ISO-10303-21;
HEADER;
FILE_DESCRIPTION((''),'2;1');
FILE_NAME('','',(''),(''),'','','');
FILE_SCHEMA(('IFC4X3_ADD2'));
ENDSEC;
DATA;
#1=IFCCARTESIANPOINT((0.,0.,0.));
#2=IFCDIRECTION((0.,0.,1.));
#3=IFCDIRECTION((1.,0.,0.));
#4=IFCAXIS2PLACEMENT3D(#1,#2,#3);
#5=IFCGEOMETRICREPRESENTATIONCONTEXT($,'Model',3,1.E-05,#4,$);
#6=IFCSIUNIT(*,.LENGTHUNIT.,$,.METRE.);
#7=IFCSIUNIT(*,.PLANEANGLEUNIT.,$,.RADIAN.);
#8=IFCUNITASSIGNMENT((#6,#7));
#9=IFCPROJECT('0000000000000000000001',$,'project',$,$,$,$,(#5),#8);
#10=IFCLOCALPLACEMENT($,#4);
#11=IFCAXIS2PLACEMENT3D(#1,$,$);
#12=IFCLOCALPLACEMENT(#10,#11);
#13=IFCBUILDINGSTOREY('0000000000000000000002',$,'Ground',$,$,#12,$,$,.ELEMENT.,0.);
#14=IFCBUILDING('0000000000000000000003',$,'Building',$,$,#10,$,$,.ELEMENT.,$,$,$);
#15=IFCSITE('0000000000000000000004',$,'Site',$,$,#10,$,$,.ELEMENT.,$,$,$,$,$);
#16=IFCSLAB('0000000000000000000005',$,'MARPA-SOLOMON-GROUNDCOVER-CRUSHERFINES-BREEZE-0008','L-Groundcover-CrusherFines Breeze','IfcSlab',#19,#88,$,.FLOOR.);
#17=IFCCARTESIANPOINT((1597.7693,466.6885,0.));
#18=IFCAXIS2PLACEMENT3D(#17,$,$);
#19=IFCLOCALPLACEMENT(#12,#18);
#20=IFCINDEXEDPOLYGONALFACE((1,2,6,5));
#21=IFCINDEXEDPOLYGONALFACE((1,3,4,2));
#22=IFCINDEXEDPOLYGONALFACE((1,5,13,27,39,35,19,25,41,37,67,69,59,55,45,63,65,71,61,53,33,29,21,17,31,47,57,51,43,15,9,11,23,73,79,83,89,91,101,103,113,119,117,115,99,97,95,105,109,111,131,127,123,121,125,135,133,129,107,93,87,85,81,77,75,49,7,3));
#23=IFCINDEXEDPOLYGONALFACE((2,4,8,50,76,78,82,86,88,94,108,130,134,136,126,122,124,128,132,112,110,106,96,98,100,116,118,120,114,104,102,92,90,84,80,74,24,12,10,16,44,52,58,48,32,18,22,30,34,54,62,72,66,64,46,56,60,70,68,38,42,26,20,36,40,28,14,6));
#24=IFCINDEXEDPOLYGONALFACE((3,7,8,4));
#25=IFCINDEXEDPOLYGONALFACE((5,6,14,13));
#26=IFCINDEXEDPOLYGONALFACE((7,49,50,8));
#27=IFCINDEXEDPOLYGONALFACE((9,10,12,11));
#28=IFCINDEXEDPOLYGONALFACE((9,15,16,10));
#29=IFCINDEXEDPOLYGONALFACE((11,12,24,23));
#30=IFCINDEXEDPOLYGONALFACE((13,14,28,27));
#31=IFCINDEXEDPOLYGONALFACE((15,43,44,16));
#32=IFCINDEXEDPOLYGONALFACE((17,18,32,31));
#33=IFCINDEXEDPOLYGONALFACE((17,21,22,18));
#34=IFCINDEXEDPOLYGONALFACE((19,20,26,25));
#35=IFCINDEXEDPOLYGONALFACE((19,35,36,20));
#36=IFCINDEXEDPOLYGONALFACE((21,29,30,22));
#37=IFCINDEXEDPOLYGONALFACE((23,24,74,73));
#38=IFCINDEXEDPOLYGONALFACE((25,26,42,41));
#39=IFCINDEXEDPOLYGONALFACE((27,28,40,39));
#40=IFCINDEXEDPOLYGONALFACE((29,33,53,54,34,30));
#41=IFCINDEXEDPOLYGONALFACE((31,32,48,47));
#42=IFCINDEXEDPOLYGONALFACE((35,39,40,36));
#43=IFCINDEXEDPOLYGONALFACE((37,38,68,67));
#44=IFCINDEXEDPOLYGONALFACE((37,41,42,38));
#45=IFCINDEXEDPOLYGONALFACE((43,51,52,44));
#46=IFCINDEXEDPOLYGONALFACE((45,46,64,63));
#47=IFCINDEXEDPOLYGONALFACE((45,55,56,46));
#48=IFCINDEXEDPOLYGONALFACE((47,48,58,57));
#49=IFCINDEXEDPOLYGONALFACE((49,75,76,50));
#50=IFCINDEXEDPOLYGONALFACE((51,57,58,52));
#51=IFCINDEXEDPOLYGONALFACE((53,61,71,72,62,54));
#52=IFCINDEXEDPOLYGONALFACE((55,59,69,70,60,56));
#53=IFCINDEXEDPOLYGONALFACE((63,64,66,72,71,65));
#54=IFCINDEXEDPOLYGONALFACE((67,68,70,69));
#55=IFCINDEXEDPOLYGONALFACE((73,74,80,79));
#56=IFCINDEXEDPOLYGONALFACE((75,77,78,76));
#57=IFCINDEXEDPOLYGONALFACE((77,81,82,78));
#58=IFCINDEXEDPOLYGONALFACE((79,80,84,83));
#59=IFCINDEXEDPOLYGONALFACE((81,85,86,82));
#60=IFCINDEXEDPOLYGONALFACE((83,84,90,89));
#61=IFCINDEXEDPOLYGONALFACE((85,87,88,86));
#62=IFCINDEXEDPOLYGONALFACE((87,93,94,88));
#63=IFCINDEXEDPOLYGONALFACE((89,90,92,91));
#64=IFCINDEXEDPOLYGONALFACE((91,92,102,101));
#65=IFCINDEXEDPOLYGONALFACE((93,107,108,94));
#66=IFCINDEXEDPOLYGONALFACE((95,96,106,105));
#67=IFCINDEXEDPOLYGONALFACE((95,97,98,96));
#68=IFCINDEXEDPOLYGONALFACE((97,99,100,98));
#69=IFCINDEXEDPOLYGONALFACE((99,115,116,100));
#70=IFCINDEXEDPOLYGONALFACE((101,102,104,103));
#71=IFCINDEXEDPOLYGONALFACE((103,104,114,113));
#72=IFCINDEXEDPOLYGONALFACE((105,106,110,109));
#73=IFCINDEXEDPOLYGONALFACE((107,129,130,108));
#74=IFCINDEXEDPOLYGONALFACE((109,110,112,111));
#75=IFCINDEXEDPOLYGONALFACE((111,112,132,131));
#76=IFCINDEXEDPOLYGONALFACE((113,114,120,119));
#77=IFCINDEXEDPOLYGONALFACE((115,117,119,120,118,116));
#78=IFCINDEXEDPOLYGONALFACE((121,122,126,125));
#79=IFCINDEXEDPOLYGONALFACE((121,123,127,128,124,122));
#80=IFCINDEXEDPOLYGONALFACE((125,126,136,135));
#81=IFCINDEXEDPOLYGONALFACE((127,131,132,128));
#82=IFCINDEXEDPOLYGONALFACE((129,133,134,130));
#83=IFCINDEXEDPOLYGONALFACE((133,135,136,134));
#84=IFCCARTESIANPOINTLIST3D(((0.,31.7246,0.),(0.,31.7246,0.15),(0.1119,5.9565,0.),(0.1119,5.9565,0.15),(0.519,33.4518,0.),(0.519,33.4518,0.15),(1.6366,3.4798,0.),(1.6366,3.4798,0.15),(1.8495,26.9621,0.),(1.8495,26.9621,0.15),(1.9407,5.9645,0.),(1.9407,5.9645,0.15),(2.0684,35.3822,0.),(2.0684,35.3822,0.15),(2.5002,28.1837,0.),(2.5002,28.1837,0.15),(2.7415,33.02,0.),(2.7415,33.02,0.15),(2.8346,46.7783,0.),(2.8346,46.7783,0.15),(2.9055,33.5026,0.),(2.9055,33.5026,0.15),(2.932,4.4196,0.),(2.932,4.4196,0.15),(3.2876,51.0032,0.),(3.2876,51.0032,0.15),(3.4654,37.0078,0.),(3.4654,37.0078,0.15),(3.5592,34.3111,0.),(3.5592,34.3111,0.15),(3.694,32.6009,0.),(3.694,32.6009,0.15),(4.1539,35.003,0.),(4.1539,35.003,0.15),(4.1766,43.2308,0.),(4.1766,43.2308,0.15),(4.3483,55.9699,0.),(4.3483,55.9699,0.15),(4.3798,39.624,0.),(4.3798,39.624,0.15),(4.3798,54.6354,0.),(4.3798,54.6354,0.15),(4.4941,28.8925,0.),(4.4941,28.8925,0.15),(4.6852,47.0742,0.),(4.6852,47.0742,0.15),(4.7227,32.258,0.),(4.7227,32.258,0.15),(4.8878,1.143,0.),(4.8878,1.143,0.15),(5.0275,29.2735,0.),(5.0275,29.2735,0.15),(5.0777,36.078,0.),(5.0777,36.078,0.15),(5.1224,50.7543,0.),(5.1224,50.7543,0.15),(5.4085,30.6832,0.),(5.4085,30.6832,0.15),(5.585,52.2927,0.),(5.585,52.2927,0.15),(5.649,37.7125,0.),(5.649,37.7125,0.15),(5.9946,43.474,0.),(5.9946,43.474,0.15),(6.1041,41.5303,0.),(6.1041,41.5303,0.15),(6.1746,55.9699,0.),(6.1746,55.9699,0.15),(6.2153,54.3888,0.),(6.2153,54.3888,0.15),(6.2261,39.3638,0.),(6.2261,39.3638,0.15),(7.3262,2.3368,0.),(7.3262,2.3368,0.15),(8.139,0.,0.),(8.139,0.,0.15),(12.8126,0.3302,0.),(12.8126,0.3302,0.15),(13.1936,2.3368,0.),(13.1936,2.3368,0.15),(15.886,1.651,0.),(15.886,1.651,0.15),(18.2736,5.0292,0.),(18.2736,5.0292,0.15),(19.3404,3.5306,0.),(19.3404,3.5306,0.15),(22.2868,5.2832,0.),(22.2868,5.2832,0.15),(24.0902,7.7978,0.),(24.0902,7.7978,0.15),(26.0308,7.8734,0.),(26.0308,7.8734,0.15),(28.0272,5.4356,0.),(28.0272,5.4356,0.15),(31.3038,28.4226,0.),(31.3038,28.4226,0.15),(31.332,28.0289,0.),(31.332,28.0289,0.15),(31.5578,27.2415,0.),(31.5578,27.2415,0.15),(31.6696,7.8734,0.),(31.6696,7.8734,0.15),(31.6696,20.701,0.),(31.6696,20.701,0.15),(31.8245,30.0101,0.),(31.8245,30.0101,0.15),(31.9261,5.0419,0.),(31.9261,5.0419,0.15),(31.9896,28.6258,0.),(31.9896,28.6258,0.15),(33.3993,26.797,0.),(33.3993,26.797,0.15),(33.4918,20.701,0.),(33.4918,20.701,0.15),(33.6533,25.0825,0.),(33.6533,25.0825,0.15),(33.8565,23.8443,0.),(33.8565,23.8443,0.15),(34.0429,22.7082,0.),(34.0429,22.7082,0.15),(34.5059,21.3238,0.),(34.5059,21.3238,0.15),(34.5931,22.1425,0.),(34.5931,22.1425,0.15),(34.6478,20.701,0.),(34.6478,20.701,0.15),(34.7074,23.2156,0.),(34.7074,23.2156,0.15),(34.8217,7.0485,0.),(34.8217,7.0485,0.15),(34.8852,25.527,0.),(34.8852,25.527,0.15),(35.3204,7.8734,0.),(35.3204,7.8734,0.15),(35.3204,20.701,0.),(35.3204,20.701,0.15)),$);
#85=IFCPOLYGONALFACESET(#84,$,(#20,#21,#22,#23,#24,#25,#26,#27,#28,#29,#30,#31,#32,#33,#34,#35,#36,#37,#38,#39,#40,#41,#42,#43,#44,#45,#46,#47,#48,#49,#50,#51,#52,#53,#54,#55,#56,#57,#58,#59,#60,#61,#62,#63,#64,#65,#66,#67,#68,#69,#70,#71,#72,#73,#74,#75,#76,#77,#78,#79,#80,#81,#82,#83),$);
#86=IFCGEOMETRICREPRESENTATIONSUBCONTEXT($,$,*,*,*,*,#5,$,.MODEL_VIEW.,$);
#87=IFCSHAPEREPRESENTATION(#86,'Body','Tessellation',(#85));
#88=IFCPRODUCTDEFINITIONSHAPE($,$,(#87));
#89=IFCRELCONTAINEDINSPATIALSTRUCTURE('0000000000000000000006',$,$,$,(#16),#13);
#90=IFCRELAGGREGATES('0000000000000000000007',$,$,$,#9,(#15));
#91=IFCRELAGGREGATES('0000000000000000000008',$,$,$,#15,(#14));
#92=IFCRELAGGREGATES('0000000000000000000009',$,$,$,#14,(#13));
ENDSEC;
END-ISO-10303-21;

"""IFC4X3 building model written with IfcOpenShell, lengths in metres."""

from ifc_helpers import new_model, si_unit, frame, origin, origin_with_axes, place, context, subcontext, project, spatial, polyline, outline, extrude, element, save


model = new_model("IFC4X3")

# Units and contexts
model_context = context("Model", 3, precision=1e-05, world=origin_with_axes())
sub_context = subcontext(model_context, None, None, "MODEL_VIEW")
ifc_project = project(units=[si_unit("LENGTHUNIT", "METRE"), si_unit("PLANEANGLEUNIT", "RADIAN")], contexts=[model_context])

# Site, building, storey
placement = place(None, origin_with_axes())
site = spatial("IfcSite", under=ifc_project, at=placement, Name="Site", CompositionType="ELEMENT")
building = spatial("IfcBuilding", under=site, at=placement, Name="Building", CompositionType="ELEMENT")
storey_placement = place(placement, origin())
storey = spatial("IfcBuildingStorey", under=building, at=storey_placement, Name="Ground", CompositionType="ELEMENT", Elevation=0.0)

# Slab
slab_1_placement = place(storey_placement, frame((1597.7693, 466.6885, 0.0)))
element("IfcSlab", 1, at=slab_1_placement, inside=storey, Name="MARPA-SOLOMON-GROUNDCOVER-CRUSHERFINES-BREEZE-0008", Description="L-Groundcover-CrusherFines Breeze", ObjectType="IfcSlab", PredefinedType="FLOOR", context=sub_context, shape_type="SweptSolid", body=[
    extrude(outline(polyline([(31.332, 28.0289), (31.3038, 28.4226), (31.8245, 30.0101), (31.9896, 28.6258), (33.3993, 26.797), (34.8852, 25.527), (34.7074, 23.2156), (34.5931, 22.1425), (34.5059, 21.3238), (34.6478, 20.701), (35.3204, 20.701), (35.3204, 7.8734), (34.8217, 7.0485), (31.9261, 5.0419), (28.0272, 5.4356), (22.2868, 5.2832), (19.3404, 3.5306), (15.886, 1.651), (12.8126, 0.3302), (8.139, 0.0), (4.8878, 1.143), (1.6366, 3.4798), (0.1119, 5.9565), (0.0, 31.7246), (0.519, 33.4518), (2.0684, 35.3822), (3.4654, 37.0078), (4.3798, 39.624), (4.1766, 43.2308), (2.8346, 46.7783), (3.2876, 51.0032), (4.3798, 54.6354), (4.3483, 55.9699), (6.1746, 55.9699), (6.2153, 54.3888), (5.585, 52.2927), (5.1224, 50.7543), (4.6852, 47.0742), (5.9946, 43.474), (6.1041, 41.5303), (6.2261, 39.3638), (5.649, 37.7125), (5.0777, 36.078), (4.1539, 35.003), (3.5592, 34.3111), (2.9055, 33.5026), (2.7415, 33.02), (3.694, 32.6009), (4.7227, 32.258), (5.4085, 30.6832), (5.0275, 29.2735), (4.4941, 28.8925), (2.5002, 28.1837), (1.8495, 26.9621), (1.9407, 5.9645), (2.932, 4.4196), (7.3262, 2.3368), (13.1936, 2.3368), (18.2736, 5.0292), (24.0902, 7.7978), (26.0308, 7.8734), (31.6696, 7.8734), (31.6696, 20.701), (33.4918, 20.701), (34.0429, 22.7082), (33.8565, 23.8443), (33.6533, 25.0825), (31.5578, 27.2415), (31.332, 28.0289)])), origin(), (0.0, 0.0, 1.0), 0.15),
])

save(model, "model.ifc")
